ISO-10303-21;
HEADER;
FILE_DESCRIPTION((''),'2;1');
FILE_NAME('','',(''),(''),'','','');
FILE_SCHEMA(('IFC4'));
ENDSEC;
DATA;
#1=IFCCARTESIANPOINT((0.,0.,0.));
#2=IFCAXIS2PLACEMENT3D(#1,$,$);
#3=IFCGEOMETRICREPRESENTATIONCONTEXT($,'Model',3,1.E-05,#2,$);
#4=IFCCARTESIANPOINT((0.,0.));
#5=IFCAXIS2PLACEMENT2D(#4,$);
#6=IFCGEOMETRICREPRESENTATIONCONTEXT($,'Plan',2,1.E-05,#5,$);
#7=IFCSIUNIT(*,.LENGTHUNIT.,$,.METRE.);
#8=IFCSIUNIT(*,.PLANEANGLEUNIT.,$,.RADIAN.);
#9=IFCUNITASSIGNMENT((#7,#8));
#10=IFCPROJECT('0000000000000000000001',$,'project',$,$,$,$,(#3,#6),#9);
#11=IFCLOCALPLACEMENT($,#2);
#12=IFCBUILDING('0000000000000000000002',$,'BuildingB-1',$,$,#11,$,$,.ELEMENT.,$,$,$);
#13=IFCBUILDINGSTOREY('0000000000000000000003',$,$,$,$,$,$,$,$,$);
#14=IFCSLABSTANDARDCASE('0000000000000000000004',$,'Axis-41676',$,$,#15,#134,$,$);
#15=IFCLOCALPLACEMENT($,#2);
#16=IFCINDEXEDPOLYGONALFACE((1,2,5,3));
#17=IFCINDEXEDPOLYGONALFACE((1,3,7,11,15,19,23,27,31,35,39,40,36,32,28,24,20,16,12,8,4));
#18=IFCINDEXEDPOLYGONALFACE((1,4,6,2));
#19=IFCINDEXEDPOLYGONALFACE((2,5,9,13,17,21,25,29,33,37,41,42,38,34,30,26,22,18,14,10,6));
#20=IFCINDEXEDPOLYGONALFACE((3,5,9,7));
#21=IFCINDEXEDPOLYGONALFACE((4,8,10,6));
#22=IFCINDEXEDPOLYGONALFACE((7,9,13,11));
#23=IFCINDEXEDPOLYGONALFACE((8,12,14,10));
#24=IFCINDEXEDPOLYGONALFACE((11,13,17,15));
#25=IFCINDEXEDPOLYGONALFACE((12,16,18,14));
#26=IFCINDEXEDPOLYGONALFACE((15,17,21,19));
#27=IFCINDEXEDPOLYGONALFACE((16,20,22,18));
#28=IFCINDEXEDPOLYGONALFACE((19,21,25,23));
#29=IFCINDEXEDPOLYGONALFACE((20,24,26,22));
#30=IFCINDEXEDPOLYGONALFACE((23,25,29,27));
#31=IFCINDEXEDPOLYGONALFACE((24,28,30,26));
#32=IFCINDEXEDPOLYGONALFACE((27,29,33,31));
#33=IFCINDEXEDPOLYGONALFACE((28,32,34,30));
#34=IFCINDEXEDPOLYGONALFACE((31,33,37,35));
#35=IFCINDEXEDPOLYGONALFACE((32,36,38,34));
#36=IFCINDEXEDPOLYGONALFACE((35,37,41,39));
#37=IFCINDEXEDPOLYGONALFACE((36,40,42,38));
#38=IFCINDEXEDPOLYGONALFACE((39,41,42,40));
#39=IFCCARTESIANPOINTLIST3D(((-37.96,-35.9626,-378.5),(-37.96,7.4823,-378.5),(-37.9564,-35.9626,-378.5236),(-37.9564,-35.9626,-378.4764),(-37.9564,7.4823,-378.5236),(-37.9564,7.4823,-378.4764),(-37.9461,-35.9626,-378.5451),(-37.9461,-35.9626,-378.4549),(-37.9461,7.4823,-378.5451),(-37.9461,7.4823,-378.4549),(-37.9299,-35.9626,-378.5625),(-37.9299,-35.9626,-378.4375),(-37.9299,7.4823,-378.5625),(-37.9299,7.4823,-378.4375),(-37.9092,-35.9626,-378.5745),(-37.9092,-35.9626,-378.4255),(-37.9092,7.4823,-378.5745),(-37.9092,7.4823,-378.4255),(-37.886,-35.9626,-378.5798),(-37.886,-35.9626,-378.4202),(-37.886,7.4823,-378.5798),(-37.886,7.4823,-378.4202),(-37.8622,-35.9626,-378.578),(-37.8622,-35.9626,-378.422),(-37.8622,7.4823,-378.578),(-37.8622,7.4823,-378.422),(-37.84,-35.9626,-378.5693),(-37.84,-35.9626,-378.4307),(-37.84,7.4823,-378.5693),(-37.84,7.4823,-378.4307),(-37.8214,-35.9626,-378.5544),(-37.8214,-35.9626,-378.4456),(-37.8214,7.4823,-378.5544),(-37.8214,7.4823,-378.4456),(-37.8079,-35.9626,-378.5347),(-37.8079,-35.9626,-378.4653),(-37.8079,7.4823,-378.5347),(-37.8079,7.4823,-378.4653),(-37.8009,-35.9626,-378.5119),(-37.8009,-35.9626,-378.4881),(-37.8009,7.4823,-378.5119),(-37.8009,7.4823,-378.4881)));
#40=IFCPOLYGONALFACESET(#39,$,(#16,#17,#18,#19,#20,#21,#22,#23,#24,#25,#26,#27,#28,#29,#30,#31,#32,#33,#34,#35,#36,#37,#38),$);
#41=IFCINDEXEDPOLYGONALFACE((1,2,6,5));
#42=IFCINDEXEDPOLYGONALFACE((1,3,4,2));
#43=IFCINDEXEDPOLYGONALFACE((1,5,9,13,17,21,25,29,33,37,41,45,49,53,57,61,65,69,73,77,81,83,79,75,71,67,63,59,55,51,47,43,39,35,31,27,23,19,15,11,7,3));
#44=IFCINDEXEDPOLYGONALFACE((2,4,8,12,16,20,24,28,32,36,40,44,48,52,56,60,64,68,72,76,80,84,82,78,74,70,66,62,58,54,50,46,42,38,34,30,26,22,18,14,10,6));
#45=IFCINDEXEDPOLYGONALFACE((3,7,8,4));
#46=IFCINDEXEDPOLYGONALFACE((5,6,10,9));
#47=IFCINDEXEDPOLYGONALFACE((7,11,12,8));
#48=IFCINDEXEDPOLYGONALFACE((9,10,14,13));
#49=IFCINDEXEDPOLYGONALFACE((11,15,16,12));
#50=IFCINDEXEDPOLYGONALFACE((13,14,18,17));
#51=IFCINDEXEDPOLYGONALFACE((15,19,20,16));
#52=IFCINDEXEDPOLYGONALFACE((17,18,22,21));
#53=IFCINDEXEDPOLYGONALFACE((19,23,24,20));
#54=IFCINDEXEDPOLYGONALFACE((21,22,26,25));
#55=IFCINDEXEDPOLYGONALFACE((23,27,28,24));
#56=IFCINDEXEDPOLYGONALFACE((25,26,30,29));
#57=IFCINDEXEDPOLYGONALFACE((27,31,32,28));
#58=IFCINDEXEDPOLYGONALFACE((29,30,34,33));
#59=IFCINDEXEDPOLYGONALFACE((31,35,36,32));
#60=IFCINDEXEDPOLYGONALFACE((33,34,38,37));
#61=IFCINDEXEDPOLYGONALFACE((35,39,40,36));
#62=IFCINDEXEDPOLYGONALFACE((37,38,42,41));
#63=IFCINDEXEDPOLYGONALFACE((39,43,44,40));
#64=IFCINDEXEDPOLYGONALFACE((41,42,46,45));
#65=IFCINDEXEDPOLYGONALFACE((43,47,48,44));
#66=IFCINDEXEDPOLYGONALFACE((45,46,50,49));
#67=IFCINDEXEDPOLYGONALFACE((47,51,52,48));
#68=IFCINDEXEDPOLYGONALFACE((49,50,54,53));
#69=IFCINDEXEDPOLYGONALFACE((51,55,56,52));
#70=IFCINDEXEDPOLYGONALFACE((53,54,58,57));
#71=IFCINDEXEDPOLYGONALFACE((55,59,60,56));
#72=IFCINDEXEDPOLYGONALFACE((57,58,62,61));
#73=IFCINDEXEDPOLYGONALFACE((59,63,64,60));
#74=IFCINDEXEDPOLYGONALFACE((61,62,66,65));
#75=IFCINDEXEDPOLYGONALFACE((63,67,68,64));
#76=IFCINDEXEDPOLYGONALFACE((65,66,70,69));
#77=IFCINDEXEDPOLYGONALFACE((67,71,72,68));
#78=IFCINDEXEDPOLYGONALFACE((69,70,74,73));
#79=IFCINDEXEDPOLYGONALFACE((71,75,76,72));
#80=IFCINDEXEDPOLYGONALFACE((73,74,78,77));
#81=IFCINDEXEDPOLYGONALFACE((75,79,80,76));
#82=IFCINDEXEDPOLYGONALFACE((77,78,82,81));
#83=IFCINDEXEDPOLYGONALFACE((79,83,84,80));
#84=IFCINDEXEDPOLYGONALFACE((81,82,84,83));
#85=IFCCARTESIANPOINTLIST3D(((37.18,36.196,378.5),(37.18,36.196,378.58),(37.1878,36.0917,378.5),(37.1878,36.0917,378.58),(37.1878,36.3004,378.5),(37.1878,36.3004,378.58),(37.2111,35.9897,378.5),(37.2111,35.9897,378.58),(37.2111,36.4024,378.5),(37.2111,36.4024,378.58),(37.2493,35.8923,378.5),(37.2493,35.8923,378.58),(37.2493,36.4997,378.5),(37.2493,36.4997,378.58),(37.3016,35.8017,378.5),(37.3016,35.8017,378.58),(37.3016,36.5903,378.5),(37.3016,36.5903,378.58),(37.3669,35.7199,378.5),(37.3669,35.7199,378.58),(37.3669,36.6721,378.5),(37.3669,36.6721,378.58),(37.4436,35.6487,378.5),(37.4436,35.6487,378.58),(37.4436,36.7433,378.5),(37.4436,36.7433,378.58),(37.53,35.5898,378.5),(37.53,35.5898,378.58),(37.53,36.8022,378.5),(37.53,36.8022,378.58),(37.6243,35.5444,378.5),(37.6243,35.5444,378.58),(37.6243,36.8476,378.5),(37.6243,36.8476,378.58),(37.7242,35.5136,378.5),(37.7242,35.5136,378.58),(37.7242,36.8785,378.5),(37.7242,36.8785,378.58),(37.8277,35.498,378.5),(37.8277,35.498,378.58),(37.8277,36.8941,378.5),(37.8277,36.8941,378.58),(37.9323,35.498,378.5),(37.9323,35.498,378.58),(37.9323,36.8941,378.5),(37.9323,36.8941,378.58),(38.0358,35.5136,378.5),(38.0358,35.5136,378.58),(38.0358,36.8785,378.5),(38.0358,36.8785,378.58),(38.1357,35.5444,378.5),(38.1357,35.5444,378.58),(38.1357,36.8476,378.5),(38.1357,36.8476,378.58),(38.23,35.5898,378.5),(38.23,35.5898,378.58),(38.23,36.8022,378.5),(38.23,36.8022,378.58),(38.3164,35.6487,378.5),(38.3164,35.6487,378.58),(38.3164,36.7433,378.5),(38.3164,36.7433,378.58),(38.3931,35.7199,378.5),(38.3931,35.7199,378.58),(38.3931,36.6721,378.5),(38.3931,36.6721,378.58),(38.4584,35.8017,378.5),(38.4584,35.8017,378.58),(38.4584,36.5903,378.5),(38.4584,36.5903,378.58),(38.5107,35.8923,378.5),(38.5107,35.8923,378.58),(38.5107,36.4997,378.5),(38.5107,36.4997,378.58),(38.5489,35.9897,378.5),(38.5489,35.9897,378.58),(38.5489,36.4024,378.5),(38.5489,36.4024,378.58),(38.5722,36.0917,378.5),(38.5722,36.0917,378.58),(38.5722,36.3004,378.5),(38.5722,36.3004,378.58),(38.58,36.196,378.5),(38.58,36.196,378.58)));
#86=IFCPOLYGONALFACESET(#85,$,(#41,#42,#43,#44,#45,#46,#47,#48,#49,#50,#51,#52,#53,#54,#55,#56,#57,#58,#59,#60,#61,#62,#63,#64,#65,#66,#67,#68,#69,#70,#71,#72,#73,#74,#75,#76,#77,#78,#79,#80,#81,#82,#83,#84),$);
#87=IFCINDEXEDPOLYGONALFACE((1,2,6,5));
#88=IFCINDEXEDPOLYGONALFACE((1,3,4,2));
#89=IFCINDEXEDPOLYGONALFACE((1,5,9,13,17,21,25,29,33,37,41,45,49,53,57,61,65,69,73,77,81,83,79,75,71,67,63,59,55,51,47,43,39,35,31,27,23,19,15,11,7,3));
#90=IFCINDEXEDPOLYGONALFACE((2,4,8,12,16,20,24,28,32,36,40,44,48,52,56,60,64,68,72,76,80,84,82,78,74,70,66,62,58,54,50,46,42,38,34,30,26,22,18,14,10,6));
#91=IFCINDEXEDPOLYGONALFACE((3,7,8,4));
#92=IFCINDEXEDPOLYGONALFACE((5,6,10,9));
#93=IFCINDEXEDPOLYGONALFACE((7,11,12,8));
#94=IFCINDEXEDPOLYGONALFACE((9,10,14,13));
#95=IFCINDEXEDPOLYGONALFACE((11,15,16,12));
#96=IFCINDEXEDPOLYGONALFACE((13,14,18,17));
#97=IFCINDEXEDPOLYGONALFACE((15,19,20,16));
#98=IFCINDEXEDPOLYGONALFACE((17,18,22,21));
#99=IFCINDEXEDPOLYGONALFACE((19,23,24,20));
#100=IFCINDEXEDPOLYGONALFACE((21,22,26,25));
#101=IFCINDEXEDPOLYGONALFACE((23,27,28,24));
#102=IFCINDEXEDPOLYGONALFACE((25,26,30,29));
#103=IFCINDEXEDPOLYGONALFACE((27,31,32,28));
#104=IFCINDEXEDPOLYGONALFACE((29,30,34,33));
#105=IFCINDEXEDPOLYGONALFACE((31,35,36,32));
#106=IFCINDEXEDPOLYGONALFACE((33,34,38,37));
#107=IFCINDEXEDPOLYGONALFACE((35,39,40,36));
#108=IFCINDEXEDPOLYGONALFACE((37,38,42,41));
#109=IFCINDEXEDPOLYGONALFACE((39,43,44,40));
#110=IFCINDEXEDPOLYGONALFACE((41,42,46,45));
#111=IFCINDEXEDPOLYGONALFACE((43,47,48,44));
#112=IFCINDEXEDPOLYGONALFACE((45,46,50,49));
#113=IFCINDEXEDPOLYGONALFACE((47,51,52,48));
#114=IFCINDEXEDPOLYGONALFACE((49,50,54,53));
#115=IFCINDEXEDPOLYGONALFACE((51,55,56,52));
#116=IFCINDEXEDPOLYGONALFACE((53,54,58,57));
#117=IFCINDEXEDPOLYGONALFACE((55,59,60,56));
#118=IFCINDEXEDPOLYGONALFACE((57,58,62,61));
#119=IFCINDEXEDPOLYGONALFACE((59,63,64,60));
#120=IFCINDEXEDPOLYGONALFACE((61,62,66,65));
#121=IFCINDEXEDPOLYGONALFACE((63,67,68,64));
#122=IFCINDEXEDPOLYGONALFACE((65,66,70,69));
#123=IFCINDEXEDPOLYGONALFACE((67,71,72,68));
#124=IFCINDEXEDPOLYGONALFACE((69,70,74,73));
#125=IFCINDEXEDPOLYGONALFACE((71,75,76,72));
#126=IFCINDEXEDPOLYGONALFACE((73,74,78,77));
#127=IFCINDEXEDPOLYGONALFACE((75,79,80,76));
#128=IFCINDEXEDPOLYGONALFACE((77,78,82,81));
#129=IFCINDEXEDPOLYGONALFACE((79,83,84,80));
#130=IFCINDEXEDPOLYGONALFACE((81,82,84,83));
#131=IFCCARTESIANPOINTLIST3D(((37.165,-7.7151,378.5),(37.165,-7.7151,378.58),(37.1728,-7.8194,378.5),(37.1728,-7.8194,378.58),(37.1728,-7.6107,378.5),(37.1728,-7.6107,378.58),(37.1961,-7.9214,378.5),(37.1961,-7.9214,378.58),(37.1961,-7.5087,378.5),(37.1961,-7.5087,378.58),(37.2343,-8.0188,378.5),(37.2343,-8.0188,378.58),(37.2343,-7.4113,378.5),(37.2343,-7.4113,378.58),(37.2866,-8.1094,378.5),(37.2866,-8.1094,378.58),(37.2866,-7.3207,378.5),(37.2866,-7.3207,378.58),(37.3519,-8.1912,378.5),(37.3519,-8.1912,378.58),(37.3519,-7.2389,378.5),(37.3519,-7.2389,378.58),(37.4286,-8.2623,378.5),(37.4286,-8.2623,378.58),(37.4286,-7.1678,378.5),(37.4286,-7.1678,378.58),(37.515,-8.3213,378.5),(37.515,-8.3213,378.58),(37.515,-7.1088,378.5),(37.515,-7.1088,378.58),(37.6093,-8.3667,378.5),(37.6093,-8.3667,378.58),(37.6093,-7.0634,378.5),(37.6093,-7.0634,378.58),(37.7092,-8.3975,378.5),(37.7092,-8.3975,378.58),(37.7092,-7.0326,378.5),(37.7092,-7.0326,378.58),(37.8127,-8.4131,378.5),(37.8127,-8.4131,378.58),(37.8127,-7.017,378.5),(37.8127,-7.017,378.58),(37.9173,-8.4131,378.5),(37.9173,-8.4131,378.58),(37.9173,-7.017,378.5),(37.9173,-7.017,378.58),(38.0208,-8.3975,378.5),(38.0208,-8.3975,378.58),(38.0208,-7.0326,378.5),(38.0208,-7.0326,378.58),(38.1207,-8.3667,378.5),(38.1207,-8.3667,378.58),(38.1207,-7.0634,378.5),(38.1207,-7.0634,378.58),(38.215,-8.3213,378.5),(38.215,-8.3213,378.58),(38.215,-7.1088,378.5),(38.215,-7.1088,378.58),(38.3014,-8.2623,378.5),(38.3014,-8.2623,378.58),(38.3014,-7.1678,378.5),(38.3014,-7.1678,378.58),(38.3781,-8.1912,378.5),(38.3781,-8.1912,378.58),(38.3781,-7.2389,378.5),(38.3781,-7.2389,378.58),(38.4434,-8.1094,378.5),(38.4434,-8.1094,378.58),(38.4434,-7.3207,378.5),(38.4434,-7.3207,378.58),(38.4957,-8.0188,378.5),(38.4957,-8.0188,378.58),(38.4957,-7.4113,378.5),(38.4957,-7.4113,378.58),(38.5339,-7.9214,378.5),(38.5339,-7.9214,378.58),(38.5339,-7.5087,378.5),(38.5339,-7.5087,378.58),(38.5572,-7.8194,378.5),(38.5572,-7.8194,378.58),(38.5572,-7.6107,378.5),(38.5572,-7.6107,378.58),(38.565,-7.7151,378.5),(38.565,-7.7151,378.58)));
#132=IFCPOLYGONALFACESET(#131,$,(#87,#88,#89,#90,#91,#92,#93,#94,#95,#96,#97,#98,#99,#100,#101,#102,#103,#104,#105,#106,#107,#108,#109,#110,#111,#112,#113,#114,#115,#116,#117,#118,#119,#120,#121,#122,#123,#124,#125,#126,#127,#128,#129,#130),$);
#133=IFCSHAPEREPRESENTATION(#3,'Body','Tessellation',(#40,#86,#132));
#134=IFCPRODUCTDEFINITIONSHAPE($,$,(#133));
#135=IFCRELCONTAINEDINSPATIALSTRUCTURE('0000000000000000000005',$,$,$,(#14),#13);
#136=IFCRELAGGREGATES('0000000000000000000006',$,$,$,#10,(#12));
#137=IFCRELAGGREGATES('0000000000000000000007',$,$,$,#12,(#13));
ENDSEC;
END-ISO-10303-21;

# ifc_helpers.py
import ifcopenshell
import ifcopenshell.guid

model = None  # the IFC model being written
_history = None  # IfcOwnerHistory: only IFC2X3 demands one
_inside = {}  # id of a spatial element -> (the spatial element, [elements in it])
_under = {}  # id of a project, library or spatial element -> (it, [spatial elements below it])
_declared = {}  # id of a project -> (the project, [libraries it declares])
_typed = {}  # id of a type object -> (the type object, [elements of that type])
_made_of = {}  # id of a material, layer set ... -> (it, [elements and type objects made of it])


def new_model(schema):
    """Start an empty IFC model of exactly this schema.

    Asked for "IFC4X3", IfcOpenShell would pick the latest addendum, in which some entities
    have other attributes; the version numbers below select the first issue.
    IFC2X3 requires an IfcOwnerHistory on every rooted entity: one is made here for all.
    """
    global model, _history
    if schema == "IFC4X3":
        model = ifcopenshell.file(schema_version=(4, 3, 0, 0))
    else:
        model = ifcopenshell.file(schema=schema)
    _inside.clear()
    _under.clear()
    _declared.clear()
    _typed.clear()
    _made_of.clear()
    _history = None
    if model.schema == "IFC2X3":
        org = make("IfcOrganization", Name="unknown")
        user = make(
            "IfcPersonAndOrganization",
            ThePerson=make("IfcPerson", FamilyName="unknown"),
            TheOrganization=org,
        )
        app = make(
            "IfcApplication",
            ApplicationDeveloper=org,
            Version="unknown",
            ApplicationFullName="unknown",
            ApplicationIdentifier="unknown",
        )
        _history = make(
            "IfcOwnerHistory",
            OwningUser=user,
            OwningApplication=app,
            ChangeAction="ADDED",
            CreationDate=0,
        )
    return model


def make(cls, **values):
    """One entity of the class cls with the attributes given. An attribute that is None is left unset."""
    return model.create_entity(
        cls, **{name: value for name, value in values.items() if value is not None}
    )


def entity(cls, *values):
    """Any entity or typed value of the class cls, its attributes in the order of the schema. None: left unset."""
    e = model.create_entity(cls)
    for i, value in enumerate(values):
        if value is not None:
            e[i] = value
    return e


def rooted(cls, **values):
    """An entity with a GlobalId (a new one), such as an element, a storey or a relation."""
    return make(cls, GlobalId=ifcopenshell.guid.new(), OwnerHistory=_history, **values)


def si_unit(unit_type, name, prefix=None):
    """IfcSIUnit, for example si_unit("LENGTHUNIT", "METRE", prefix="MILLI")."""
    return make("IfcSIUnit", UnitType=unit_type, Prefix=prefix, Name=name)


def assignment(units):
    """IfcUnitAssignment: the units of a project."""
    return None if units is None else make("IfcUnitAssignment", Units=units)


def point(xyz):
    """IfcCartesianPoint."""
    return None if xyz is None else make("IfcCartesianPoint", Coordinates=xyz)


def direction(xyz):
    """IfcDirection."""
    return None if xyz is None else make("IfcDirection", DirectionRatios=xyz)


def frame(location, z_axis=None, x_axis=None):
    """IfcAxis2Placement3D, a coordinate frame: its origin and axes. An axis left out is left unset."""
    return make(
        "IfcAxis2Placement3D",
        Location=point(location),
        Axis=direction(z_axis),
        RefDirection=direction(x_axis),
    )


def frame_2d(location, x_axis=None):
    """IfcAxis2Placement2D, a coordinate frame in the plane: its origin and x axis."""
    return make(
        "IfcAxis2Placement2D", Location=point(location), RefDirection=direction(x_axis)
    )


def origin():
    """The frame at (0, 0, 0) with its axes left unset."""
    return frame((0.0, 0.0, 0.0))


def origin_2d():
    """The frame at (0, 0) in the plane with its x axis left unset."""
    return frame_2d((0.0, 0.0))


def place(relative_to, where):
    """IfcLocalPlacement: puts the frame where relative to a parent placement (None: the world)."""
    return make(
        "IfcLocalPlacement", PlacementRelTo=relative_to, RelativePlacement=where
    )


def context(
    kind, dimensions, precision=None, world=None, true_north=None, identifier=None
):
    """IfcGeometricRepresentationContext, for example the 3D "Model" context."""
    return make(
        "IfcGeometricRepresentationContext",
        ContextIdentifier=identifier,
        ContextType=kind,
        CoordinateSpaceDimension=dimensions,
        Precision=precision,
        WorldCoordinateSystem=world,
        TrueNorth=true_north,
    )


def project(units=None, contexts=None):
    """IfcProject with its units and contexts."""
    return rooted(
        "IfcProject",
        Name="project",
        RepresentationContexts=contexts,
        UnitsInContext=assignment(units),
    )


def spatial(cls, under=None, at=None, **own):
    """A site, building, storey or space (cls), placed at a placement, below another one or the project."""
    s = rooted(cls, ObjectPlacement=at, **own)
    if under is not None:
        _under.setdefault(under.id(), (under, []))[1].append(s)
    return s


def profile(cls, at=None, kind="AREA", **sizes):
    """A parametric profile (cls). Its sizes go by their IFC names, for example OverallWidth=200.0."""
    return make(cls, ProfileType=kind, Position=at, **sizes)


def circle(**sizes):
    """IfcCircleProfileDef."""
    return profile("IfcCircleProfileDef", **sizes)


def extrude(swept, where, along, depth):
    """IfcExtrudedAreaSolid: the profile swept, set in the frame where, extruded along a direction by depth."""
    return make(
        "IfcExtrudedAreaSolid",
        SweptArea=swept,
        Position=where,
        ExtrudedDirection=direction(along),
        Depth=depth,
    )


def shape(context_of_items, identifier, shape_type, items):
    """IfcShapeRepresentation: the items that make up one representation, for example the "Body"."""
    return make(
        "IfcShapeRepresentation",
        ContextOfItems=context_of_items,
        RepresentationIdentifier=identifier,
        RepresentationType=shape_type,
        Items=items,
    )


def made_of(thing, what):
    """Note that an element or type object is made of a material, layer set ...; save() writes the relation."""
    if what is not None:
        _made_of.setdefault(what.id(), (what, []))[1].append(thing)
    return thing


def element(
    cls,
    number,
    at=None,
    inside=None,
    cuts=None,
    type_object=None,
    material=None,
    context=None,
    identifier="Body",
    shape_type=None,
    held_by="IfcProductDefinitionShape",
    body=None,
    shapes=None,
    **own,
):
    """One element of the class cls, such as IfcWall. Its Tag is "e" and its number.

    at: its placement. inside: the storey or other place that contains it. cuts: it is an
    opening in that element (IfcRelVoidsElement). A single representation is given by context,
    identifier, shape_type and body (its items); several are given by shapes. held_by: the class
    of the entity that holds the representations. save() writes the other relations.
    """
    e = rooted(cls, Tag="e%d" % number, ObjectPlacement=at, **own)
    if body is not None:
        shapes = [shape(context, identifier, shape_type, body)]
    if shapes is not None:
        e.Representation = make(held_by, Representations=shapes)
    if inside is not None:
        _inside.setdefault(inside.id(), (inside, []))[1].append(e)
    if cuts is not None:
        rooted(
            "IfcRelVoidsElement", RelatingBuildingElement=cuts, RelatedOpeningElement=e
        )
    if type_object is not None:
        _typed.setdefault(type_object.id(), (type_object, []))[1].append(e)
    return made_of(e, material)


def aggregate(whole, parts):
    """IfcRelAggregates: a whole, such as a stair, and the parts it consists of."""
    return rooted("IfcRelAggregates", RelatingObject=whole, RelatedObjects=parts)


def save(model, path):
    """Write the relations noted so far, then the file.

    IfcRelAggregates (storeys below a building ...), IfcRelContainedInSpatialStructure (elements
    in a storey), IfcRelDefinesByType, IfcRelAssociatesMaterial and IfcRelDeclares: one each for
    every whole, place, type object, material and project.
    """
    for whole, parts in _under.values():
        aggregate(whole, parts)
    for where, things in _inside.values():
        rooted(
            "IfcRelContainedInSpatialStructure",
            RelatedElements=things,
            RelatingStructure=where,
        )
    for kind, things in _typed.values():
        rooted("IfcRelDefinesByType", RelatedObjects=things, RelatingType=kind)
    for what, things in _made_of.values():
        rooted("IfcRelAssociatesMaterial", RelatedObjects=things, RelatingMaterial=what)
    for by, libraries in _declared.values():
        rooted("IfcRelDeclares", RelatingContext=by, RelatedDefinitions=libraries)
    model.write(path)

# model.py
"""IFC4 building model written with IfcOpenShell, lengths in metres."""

from ifc_helpers import new_model, entity, si_unit, frame, origin, origin_2d, place, context, project, spatial, circle, extrude, element, save


model = new_model("IFC4")

# Units and contexts
model_context = context("Model", 3, precision=1e-05, world=origin())
plan_context = context("Plan", 2, precision=1e-05, world=origin_2d())
ifc_project = project(units=[si_unit("LENGTHUNIT", "METRE"), si_unit("PLANEANGLEUNIT", "RADIAN")], contexts=[model_context, plan_context])

# Building, storey
building_placement = place(None, origin())
building = spatial("IfcBuilding", under=ifc_project, at=building_placement, Name="BuildingB-1", CompositionType="ELEMENT")
storey = spatial("IfcBuildingStorey", under=building)

# Slab
element("IfcSlabStandardCase", 1, inside=storey, Name="Axis-41676", context=model_context, shape_type="AdvancedSweptSolid", body=[
    entity("IfcSurfaceCurveSweptAreaSolid", entity("IfcCircleProfileDef", "AREA", None, None, 0.08), None, entity("IfcPolyline", [entity("IfcCartesianPoint", [37.88, 35.9626, 378.5]), entity("IfcCartesianPoint", [37.88, -7.4823, 378.5])]), None, None, entity("IfcPlane", entity("IfcAxis2Placement3D", entity("IfcCartesianPoint", [37.88, 35.9626, 378.5]), entity("IfcDirection", [0.0, 0.0, 1.0]), entity("IfcDirection", [1.0, 0.0, 0.0])))),
    extrude(circle(Radius=0.7), frame((37.88, 36.196, 378.5)), (0.0, 0.0, 1.0), 0.08),
    extrude(circle(Radius=0.7), frame((37.865, -7.7151, 378.5)), (0.0, 0.0, 1.0), 0.08),
])

save(model, "model.ifc")
